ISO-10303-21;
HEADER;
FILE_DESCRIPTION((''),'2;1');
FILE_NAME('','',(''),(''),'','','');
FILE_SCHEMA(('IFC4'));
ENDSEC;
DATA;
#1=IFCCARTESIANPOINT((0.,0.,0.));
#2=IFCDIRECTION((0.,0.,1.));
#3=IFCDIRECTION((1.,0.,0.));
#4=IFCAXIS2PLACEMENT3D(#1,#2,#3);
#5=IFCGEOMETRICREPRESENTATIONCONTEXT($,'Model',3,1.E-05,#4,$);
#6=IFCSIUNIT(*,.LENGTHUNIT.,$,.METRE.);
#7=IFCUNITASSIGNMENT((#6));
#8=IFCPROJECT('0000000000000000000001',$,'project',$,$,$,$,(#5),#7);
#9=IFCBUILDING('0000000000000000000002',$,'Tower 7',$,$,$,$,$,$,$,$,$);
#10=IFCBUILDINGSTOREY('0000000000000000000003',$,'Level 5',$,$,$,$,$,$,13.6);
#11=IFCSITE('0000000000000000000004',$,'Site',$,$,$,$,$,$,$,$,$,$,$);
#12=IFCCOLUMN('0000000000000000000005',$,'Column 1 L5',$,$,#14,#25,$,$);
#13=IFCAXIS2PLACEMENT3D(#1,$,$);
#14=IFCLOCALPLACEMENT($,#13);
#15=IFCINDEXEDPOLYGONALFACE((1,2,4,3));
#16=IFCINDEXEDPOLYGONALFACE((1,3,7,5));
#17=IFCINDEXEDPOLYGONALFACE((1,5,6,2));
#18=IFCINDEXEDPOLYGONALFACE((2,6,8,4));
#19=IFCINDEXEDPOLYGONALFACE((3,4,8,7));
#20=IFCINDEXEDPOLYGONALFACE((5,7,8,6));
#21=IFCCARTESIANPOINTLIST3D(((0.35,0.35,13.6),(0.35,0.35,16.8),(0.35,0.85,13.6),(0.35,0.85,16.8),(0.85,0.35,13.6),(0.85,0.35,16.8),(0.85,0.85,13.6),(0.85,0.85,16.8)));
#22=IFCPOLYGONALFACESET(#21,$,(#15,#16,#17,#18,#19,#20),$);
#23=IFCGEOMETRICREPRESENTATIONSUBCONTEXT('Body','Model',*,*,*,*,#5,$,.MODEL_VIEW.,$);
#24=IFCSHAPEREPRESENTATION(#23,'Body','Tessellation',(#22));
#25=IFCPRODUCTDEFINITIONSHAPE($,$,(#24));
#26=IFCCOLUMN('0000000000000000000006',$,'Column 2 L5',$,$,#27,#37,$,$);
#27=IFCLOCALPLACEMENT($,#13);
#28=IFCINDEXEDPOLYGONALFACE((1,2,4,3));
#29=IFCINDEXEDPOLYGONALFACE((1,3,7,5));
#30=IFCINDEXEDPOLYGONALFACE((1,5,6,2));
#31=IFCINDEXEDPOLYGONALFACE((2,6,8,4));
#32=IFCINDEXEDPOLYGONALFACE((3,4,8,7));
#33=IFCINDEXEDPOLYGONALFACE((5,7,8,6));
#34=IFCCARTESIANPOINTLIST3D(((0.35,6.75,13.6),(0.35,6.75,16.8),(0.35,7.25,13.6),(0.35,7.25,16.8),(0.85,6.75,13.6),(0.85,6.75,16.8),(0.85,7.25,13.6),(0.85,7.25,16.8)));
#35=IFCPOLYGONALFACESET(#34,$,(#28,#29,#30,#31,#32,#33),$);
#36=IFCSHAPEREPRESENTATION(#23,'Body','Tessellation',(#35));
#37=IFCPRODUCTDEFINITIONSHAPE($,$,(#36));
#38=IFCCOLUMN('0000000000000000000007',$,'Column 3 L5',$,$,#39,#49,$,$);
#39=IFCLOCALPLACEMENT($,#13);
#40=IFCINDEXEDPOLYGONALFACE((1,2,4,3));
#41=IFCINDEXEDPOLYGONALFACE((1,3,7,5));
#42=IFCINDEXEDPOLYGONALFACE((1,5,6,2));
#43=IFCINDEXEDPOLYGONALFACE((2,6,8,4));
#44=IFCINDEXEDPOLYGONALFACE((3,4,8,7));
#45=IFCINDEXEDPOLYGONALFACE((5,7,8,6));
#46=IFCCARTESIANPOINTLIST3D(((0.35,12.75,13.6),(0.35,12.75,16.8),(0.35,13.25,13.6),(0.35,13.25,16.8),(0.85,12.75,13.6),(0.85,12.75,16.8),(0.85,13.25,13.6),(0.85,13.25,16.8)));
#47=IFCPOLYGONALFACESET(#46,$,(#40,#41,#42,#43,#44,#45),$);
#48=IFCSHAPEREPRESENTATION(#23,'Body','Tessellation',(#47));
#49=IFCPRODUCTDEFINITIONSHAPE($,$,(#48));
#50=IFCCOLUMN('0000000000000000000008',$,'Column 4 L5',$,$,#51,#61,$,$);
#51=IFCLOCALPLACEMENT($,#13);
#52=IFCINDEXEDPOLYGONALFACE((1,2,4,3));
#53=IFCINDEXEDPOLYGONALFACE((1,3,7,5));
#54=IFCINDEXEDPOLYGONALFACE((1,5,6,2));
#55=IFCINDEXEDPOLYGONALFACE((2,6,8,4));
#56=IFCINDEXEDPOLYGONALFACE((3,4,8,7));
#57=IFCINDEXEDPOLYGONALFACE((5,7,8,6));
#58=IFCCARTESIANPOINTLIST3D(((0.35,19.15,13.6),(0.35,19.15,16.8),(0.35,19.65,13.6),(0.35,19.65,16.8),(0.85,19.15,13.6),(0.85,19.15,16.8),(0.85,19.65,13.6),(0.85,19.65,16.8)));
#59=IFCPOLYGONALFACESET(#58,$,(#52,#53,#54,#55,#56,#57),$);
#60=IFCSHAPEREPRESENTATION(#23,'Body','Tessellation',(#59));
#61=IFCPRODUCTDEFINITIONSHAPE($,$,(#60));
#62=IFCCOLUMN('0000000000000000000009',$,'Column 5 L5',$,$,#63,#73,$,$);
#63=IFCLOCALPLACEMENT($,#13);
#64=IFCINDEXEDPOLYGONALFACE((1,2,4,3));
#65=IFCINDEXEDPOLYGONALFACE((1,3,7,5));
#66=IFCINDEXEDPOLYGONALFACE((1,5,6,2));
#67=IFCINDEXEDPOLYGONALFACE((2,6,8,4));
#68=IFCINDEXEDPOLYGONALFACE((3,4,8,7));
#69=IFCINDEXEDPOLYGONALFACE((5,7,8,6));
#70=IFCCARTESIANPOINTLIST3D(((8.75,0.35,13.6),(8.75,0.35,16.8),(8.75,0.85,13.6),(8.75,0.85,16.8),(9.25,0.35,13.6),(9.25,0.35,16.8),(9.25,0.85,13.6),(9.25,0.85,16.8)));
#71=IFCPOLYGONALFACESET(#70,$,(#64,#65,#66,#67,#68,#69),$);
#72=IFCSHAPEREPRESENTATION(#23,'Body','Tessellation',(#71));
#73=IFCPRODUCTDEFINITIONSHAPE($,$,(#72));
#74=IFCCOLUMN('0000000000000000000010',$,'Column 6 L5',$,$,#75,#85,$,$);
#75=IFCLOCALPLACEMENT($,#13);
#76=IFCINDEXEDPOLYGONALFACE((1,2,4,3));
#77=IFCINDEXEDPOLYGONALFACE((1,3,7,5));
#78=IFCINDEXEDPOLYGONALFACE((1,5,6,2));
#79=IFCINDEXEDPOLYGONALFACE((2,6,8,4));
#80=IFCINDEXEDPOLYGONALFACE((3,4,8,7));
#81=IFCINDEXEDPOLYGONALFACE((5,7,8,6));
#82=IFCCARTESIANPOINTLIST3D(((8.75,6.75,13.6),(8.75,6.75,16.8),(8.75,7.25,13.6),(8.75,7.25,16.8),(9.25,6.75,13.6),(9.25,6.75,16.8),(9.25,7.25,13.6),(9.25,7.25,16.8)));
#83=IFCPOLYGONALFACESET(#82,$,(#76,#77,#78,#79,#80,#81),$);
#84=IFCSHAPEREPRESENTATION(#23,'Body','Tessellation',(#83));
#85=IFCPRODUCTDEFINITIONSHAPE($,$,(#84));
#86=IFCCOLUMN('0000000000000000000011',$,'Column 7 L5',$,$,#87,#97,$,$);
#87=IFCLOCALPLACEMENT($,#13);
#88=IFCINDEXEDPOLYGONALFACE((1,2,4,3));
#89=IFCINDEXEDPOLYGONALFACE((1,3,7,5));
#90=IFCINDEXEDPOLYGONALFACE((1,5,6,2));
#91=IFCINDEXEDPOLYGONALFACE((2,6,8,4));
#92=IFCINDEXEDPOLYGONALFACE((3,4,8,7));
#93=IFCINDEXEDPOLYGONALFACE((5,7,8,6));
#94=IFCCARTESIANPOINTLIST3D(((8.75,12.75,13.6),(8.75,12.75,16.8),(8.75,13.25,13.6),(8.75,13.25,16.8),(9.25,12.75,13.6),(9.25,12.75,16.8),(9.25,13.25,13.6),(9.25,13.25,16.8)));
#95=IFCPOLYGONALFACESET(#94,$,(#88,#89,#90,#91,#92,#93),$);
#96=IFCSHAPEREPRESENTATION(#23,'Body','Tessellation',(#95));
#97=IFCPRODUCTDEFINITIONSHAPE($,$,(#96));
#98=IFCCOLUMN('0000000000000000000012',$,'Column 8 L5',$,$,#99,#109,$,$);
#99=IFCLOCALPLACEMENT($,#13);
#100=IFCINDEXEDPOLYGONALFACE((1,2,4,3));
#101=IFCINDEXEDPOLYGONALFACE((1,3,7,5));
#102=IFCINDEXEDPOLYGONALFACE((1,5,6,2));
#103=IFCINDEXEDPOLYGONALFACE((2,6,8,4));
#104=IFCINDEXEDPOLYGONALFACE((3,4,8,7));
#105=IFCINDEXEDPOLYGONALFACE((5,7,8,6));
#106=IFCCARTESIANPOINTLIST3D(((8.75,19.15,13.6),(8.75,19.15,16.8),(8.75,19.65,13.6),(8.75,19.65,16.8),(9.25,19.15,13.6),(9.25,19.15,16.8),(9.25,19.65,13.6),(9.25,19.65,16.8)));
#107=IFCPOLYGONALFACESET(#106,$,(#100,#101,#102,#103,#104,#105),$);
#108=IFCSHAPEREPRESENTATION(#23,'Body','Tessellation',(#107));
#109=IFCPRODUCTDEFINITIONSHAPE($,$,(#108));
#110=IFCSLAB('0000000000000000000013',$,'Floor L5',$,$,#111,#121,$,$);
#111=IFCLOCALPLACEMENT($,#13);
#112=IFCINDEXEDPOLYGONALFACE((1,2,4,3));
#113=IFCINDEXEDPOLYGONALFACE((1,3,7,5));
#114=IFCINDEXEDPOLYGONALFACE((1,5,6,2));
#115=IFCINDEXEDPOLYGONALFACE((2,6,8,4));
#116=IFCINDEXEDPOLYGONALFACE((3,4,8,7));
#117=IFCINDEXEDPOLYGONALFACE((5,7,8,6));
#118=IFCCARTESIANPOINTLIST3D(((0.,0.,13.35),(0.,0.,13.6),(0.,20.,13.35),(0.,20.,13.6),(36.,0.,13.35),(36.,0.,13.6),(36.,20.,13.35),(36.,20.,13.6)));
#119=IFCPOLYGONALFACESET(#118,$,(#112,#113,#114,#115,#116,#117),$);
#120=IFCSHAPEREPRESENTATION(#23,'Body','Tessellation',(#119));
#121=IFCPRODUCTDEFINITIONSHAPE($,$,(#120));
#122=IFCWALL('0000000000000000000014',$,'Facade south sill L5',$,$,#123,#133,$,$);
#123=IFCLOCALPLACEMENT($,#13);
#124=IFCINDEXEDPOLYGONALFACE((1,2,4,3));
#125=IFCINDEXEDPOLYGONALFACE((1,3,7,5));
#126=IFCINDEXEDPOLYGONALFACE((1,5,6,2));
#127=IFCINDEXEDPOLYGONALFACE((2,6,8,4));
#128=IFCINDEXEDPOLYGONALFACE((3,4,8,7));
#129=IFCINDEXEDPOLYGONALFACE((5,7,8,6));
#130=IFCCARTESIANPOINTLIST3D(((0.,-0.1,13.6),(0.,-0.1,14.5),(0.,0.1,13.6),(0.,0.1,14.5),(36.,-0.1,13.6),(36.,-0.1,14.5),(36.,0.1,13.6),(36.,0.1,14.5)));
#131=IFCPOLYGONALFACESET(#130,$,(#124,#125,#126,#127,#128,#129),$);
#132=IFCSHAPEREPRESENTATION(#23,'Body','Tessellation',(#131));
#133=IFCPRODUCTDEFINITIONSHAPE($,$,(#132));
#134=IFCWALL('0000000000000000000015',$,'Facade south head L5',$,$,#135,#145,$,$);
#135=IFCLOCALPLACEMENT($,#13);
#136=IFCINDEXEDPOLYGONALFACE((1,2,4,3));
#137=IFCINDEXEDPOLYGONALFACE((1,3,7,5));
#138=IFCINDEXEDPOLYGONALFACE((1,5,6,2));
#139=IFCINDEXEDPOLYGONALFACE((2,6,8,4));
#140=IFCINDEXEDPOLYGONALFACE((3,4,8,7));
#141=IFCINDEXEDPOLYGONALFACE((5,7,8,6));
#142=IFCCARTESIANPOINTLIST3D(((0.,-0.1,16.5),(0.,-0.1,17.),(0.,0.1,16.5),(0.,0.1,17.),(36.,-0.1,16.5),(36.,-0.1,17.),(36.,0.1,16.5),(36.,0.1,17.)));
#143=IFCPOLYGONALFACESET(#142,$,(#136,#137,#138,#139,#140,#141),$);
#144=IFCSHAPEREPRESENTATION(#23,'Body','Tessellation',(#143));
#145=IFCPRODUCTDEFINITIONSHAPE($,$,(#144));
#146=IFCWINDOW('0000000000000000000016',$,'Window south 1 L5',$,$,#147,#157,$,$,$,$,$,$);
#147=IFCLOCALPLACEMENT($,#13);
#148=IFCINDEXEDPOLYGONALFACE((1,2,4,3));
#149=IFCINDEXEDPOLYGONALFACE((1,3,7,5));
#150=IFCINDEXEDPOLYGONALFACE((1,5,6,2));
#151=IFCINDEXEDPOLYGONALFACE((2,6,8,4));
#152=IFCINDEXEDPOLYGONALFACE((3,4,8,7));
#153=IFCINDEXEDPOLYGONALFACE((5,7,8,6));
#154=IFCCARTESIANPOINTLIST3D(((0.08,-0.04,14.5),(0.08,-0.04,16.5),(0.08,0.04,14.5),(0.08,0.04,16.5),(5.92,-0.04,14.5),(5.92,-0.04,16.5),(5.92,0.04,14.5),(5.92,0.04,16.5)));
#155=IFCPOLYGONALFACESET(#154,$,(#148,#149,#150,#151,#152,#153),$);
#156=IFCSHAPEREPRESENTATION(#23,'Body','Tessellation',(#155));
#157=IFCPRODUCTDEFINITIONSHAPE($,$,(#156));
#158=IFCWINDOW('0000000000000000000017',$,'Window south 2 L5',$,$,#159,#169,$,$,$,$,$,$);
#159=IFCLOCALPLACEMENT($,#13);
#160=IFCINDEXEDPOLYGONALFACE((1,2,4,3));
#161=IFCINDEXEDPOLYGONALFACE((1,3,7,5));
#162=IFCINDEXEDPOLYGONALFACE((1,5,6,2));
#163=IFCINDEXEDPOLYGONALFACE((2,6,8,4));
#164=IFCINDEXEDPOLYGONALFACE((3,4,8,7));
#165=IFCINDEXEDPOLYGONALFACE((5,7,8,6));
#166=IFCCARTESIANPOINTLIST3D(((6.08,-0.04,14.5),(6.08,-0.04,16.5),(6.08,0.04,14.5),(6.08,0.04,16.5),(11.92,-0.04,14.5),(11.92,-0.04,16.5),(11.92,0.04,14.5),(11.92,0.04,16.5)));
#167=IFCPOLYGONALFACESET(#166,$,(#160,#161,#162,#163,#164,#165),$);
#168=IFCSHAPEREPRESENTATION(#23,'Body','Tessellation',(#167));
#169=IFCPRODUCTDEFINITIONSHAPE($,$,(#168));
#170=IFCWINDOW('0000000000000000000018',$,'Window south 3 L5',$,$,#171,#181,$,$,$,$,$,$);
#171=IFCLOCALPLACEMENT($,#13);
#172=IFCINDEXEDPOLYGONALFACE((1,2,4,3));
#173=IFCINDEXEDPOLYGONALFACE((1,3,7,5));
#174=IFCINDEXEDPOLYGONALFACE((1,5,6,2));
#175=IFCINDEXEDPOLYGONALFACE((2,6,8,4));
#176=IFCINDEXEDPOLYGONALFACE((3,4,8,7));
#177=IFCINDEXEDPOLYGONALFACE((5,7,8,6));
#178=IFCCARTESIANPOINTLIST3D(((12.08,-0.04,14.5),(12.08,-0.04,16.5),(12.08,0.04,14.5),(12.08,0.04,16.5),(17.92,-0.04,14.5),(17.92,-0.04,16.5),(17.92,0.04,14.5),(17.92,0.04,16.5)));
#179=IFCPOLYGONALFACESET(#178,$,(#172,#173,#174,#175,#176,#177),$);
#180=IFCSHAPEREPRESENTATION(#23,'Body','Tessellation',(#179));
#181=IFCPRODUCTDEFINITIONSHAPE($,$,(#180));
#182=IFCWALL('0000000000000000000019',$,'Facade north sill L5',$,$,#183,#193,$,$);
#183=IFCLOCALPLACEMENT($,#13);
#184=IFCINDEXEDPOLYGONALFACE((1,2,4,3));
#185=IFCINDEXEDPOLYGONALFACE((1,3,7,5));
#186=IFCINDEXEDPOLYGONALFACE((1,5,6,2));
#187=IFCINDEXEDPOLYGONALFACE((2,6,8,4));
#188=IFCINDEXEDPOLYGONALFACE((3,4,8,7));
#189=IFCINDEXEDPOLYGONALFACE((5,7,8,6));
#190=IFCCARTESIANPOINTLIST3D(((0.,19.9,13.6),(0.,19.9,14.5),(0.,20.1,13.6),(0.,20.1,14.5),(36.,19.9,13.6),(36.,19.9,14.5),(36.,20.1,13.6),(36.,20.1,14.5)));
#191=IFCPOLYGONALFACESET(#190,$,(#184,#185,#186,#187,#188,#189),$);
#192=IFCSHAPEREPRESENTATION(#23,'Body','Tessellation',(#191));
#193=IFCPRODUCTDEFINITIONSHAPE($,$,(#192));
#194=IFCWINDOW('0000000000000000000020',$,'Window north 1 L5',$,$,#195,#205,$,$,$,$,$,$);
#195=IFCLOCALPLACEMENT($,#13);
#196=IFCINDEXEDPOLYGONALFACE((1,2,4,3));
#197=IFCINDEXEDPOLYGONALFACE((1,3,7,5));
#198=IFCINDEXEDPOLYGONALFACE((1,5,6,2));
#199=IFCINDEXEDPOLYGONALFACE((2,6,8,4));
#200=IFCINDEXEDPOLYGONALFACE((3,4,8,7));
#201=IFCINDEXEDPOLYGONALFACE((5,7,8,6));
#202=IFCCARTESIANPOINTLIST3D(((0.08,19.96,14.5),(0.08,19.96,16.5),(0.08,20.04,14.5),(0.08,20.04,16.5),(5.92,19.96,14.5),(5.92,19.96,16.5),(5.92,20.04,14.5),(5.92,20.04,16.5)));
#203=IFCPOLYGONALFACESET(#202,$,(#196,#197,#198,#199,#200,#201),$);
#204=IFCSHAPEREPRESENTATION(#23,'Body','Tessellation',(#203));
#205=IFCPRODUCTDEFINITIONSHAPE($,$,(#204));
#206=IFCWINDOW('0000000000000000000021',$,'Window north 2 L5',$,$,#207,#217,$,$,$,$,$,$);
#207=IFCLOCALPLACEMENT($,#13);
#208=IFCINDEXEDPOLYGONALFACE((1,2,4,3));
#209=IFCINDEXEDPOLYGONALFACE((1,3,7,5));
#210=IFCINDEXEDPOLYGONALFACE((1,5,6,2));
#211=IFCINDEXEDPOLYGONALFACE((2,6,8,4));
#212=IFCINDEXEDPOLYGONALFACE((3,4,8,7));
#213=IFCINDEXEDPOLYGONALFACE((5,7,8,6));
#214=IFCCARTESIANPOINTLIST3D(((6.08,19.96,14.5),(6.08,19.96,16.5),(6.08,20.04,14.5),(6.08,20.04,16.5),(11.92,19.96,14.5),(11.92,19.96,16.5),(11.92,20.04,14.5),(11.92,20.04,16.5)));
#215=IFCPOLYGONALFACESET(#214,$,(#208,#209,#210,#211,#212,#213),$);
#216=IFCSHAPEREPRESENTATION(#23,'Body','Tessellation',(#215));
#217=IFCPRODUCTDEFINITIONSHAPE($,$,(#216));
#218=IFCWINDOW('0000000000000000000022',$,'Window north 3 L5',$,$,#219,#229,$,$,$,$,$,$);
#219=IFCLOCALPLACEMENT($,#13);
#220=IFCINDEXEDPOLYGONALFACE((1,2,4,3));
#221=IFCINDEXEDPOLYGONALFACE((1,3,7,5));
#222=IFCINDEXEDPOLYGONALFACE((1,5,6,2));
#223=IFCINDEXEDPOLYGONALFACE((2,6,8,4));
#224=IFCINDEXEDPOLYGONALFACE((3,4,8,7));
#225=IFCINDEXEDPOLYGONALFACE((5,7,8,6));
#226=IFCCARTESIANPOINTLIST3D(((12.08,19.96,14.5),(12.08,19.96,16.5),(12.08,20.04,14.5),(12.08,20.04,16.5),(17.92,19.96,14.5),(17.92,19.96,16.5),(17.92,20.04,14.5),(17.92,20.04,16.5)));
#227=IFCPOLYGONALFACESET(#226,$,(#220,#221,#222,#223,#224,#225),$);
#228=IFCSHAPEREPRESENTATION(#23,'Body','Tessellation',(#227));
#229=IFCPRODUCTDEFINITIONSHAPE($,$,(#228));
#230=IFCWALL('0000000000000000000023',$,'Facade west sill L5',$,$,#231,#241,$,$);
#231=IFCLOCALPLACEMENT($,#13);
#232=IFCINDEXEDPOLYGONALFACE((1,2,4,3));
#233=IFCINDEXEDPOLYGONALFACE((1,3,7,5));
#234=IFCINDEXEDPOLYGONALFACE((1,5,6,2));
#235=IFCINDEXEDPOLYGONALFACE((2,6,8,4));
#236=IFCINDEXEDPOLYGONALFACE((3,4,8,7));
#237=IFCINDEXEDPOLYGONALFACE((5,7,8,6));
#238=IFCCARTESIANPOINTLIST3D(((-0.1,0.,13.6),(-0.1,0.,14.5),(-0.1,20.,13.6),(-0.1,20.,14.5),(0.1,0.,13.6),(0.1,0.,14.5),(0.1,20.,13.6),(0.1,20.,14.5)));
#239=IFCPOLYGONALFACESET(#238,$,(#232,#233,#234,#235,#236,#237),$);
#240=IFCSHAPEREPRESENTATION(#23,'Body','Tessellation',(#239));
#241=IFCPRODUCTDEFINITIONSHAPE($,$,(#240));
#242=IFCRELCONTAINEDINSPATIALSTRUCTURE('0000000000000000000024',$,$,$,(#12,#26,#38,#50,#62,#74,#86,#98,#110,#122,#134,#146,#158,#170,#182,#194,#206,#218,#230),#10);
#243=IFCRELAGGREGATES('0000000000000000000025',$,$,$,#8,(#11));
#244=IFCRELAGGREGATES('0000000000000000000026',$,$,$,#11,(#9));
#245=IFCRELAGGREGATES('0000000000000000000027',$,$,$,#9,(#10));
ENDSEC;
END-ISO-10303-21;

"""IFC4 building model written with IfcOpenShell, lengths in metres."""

from ifc_helpers import new_model, si_unit, frame, origin, origin_with_axes, origin_2d, place, context, subcontext, project, spatial, rectangle, extrude, element, save


model = new_model("IFC4")

# Units and contexts
model_context = context("Model", 3, precision=1e-05, world=origin_with_axes())
body_context = subcontext(model_context, "Body", "Model", "MODEL_VIEW")
ifc_project = project(units=[si_unit("LENGTHUNIT", "METRE")], contexts=[model_context])

# Site, building, storey
site = spatial("IfcSite", under=ifc_project, Name="Site")
building = spatial("IfcBuilding", under=site, Name="Tower 7")
storey = spatial("IfcBuildingStorey", under=building, Name="Level 5", Elevation=13.6)

# Columns
for number, where, z_axis, x_axis, name in (
    (1, (0.6, 0.6, 13.6), (0.0, 0.0, 1.0), (1.0, 0.0, 0.0), "Column 1 L5"),
    (2, (0.6, 7.0, 13.6), (0.0, 0.0, 1.0), (1.0, 0.0, 0.0), "Column 2 L5"),
    (3, (0.6, 13.0, 13.6), (0.0, 0.0, 1.0), (1.0, 0.0, 0.0), "Column 3 L5"),
    (4, (0.6, 19.4, 13.6), (0.0, 0.0, 1.0), (1.0, 0.0, 0.0), "Column 4 L5"),
    (5, (9.0, 0.6, 13.6), (0.0, 0.0, 1.0), (1.0, 0.0, 0.0), "Column 5 L5"),
    (6, (9.0, 7.0, 13.6), (0.0, 0.0, 1.0), (1.0, 0.0, 0.0), "Column 6 L5"),
    (7, (9.0, 13.0, 13.6), (0.0, 0.0, 1.0), (1.0, 0.0, 0.0), "Column 7 L5"),
    (8, (9.0, 19.4, 13.6), (0.0, 0.0, 1.0), (1.0, 0.0, 0.0), "Column 8 L5"),
):
    element("IfcColumn", number, at=place(None, frame(where, z_axis=z_axis, x_axis=x_axis)), inside=storey, Name=name, context=body_context, shape_type="SweptSolid", body=[
        extrude(rectangle(XDim=0.5, YDim=0.5, at=origin_2d()), origin(), (0.0, 0.0, 1.0), 3.2),
    ])

# Slab
slab_placement = place(None, frame((18.0, 10.0, 13.35), z_axis=(0.0, 0.0, 1.0), x_axis=(1.0, 0.0, 0.0)))
element("IfcSlab", 9, at=slab_placement, inside=storey, Name="Floor L5", context=body_context, shape_type="SweptSolid", body=[
    extrude(rectangle(XDim=36.0, YDim=20.0, at=origin_2d()), origin(), (0.0, 0.0, 1.0), 0.25),
])

# Walls
wall_1_placement = place(None, frame((18.0, 0.0, 13.6), z_axis=(0.0, 0.0, 1.0), x_axis=(1.0, 0.0, 0.0)))
element("IfcWall", 10, at=wall_1_placement, inside=storey, Name="Facade south sill L5", context=body_context, shape_type="SweptSolid", body=[
    extrude(rectangle(XDim=36.0, YDim=0.2, at=origin_2d()), origin(), (0.0, 0.0, 1.0), 0.9),
])
wall_2_placement = place(None, frame((18.0, 0.0, 16.5), z_axis=(0.0, 0.0, 1.0), x_axis=(1.0, 0.0, 0.0)))
element("IfcWall", 11, at=wall_2_placement, inside=storey, Name="Facade south head L5", context=body_context, shape_type="SweptSolid", body=[
    extrude(rectangle(XDim=36.0, YDim=0.2, at=origin_2d()), origin(), (0.0, 0.0, 1.0), 0.5),
])

# Windows
for number, where, z_axis, x_axis, name in (
    (12, (3.0, 0.0, 14.5), (0.0, 0.0, 1.0), (1.0, 0.0, 0.0), "Window south 1 L5"),
    (13, (9.0, 0.0, 14.5), (0.0, 0.0, 1.0), (1.0, 0.0, 0.0), "Window south 2 L5"),
):
    element("IfcWindow", number, at=place(None, frame(where, z_axis=z_axis, x_axis=x_axis)), inside=storey, Name=name, context=body_context, shape_type="SweptSolid", body=[
        extrude(rectangle(XDim=5.84, YDim=0.08, at=origin_2d()), origin(), (0.0, 0.0, 1.0), 2.0),
    ])
window_1_placement = place(None, frame((15.0, 0.0, 14.5), z_axis=(0.0, 0.0, 1.0), x_axis=(1.0, 0.0, 0.0)))
element("IfcWindow", 14, at=window_1_placement, inside=storey, Name="Window south 3 L5", context=body_context, shape_type="SweptSolid", body=[
    extrude(rectangle(XDim=5.84, YDim=0.08, at=origin_2d()), origin(), (0.0, 0.0, 1.0), 2.0),
])

# Wall
wall_3_placement = place(None, frame((18.0, 20.0, 13.6), z_axis=(0.0, 0.0, 1.0), x_axis=(1.0, 0.0, 0.0)))
element("IfcWall", 15, at=wall_3_placement, inside=storey, Name="Facade north sill L5", context=body_context, shape_type="SweptSolid", body=[
    extrude(rectangle(XDim=36.0, YDim=0.2, at=origin_2d()), origin(), (0.0, 0.0, 1.0), 0.9),
])

# Windows
for number, where, z_axis, x_axis, name in (
    (16, (3.0, 20.0, 14.5), (0.0, 0.0, 1.0), (1.0, 0.0, 0.0), "Window north 1 L5"),
    (17, (9.0, 20.0, 14.5), (0.0, 0.0, 1.0), (1.0, 0.0, 0.0), "Window north 2 L5"),
):
    element("IfcWindow", number, at=place(None, frame(where, z_axis=z_axis, x_axis=x_axis)), inside=storey, Name=name, context=body_context, shape_type="SweptSolid", body=[
        extrude(rectangle(XDim=5.84, YDim=0.08, at=origin_2d()), origin(), (0.0, 0.0, 1.0), 2.0),
    ])
window_2_placement = place(None, frame((15.0, 20.0, 14.5), z_axis=(0.0, 0.0, 1.0), x_axis=(1.0, 0.0, 0.0)))
element("IfcWindow", 18, at=window_2_placement, inside=storey, Name="Window north 3 L5", context=body_context, shape_type="SweptSolid", body=[
    extrude(rectangle(XDim=5.84, YDim=0.08, at=origin_2d()), origin(), (0.0, 0.0, 1.0), 2.0),
])

# Wall
wall_4_placement = place(None, frame((0.0, 10.0, 13.6), z_axis=(0.0, 0.0, 1.0), x_axis=(1.0, 0.0, 0.0)))
element("IfcWall", 19, at=wall_4_placement, inside=storey, Name="Facade west sill L5", context=body_context, shape_type="SweptSolid", body=[
    extrude(rectangle(XDim=0.2, YDim=20.0, at=origin_2d()), origin(), (0.0, 0.0, 1.0), 0.9),
])

save(model, "model.ifc")
